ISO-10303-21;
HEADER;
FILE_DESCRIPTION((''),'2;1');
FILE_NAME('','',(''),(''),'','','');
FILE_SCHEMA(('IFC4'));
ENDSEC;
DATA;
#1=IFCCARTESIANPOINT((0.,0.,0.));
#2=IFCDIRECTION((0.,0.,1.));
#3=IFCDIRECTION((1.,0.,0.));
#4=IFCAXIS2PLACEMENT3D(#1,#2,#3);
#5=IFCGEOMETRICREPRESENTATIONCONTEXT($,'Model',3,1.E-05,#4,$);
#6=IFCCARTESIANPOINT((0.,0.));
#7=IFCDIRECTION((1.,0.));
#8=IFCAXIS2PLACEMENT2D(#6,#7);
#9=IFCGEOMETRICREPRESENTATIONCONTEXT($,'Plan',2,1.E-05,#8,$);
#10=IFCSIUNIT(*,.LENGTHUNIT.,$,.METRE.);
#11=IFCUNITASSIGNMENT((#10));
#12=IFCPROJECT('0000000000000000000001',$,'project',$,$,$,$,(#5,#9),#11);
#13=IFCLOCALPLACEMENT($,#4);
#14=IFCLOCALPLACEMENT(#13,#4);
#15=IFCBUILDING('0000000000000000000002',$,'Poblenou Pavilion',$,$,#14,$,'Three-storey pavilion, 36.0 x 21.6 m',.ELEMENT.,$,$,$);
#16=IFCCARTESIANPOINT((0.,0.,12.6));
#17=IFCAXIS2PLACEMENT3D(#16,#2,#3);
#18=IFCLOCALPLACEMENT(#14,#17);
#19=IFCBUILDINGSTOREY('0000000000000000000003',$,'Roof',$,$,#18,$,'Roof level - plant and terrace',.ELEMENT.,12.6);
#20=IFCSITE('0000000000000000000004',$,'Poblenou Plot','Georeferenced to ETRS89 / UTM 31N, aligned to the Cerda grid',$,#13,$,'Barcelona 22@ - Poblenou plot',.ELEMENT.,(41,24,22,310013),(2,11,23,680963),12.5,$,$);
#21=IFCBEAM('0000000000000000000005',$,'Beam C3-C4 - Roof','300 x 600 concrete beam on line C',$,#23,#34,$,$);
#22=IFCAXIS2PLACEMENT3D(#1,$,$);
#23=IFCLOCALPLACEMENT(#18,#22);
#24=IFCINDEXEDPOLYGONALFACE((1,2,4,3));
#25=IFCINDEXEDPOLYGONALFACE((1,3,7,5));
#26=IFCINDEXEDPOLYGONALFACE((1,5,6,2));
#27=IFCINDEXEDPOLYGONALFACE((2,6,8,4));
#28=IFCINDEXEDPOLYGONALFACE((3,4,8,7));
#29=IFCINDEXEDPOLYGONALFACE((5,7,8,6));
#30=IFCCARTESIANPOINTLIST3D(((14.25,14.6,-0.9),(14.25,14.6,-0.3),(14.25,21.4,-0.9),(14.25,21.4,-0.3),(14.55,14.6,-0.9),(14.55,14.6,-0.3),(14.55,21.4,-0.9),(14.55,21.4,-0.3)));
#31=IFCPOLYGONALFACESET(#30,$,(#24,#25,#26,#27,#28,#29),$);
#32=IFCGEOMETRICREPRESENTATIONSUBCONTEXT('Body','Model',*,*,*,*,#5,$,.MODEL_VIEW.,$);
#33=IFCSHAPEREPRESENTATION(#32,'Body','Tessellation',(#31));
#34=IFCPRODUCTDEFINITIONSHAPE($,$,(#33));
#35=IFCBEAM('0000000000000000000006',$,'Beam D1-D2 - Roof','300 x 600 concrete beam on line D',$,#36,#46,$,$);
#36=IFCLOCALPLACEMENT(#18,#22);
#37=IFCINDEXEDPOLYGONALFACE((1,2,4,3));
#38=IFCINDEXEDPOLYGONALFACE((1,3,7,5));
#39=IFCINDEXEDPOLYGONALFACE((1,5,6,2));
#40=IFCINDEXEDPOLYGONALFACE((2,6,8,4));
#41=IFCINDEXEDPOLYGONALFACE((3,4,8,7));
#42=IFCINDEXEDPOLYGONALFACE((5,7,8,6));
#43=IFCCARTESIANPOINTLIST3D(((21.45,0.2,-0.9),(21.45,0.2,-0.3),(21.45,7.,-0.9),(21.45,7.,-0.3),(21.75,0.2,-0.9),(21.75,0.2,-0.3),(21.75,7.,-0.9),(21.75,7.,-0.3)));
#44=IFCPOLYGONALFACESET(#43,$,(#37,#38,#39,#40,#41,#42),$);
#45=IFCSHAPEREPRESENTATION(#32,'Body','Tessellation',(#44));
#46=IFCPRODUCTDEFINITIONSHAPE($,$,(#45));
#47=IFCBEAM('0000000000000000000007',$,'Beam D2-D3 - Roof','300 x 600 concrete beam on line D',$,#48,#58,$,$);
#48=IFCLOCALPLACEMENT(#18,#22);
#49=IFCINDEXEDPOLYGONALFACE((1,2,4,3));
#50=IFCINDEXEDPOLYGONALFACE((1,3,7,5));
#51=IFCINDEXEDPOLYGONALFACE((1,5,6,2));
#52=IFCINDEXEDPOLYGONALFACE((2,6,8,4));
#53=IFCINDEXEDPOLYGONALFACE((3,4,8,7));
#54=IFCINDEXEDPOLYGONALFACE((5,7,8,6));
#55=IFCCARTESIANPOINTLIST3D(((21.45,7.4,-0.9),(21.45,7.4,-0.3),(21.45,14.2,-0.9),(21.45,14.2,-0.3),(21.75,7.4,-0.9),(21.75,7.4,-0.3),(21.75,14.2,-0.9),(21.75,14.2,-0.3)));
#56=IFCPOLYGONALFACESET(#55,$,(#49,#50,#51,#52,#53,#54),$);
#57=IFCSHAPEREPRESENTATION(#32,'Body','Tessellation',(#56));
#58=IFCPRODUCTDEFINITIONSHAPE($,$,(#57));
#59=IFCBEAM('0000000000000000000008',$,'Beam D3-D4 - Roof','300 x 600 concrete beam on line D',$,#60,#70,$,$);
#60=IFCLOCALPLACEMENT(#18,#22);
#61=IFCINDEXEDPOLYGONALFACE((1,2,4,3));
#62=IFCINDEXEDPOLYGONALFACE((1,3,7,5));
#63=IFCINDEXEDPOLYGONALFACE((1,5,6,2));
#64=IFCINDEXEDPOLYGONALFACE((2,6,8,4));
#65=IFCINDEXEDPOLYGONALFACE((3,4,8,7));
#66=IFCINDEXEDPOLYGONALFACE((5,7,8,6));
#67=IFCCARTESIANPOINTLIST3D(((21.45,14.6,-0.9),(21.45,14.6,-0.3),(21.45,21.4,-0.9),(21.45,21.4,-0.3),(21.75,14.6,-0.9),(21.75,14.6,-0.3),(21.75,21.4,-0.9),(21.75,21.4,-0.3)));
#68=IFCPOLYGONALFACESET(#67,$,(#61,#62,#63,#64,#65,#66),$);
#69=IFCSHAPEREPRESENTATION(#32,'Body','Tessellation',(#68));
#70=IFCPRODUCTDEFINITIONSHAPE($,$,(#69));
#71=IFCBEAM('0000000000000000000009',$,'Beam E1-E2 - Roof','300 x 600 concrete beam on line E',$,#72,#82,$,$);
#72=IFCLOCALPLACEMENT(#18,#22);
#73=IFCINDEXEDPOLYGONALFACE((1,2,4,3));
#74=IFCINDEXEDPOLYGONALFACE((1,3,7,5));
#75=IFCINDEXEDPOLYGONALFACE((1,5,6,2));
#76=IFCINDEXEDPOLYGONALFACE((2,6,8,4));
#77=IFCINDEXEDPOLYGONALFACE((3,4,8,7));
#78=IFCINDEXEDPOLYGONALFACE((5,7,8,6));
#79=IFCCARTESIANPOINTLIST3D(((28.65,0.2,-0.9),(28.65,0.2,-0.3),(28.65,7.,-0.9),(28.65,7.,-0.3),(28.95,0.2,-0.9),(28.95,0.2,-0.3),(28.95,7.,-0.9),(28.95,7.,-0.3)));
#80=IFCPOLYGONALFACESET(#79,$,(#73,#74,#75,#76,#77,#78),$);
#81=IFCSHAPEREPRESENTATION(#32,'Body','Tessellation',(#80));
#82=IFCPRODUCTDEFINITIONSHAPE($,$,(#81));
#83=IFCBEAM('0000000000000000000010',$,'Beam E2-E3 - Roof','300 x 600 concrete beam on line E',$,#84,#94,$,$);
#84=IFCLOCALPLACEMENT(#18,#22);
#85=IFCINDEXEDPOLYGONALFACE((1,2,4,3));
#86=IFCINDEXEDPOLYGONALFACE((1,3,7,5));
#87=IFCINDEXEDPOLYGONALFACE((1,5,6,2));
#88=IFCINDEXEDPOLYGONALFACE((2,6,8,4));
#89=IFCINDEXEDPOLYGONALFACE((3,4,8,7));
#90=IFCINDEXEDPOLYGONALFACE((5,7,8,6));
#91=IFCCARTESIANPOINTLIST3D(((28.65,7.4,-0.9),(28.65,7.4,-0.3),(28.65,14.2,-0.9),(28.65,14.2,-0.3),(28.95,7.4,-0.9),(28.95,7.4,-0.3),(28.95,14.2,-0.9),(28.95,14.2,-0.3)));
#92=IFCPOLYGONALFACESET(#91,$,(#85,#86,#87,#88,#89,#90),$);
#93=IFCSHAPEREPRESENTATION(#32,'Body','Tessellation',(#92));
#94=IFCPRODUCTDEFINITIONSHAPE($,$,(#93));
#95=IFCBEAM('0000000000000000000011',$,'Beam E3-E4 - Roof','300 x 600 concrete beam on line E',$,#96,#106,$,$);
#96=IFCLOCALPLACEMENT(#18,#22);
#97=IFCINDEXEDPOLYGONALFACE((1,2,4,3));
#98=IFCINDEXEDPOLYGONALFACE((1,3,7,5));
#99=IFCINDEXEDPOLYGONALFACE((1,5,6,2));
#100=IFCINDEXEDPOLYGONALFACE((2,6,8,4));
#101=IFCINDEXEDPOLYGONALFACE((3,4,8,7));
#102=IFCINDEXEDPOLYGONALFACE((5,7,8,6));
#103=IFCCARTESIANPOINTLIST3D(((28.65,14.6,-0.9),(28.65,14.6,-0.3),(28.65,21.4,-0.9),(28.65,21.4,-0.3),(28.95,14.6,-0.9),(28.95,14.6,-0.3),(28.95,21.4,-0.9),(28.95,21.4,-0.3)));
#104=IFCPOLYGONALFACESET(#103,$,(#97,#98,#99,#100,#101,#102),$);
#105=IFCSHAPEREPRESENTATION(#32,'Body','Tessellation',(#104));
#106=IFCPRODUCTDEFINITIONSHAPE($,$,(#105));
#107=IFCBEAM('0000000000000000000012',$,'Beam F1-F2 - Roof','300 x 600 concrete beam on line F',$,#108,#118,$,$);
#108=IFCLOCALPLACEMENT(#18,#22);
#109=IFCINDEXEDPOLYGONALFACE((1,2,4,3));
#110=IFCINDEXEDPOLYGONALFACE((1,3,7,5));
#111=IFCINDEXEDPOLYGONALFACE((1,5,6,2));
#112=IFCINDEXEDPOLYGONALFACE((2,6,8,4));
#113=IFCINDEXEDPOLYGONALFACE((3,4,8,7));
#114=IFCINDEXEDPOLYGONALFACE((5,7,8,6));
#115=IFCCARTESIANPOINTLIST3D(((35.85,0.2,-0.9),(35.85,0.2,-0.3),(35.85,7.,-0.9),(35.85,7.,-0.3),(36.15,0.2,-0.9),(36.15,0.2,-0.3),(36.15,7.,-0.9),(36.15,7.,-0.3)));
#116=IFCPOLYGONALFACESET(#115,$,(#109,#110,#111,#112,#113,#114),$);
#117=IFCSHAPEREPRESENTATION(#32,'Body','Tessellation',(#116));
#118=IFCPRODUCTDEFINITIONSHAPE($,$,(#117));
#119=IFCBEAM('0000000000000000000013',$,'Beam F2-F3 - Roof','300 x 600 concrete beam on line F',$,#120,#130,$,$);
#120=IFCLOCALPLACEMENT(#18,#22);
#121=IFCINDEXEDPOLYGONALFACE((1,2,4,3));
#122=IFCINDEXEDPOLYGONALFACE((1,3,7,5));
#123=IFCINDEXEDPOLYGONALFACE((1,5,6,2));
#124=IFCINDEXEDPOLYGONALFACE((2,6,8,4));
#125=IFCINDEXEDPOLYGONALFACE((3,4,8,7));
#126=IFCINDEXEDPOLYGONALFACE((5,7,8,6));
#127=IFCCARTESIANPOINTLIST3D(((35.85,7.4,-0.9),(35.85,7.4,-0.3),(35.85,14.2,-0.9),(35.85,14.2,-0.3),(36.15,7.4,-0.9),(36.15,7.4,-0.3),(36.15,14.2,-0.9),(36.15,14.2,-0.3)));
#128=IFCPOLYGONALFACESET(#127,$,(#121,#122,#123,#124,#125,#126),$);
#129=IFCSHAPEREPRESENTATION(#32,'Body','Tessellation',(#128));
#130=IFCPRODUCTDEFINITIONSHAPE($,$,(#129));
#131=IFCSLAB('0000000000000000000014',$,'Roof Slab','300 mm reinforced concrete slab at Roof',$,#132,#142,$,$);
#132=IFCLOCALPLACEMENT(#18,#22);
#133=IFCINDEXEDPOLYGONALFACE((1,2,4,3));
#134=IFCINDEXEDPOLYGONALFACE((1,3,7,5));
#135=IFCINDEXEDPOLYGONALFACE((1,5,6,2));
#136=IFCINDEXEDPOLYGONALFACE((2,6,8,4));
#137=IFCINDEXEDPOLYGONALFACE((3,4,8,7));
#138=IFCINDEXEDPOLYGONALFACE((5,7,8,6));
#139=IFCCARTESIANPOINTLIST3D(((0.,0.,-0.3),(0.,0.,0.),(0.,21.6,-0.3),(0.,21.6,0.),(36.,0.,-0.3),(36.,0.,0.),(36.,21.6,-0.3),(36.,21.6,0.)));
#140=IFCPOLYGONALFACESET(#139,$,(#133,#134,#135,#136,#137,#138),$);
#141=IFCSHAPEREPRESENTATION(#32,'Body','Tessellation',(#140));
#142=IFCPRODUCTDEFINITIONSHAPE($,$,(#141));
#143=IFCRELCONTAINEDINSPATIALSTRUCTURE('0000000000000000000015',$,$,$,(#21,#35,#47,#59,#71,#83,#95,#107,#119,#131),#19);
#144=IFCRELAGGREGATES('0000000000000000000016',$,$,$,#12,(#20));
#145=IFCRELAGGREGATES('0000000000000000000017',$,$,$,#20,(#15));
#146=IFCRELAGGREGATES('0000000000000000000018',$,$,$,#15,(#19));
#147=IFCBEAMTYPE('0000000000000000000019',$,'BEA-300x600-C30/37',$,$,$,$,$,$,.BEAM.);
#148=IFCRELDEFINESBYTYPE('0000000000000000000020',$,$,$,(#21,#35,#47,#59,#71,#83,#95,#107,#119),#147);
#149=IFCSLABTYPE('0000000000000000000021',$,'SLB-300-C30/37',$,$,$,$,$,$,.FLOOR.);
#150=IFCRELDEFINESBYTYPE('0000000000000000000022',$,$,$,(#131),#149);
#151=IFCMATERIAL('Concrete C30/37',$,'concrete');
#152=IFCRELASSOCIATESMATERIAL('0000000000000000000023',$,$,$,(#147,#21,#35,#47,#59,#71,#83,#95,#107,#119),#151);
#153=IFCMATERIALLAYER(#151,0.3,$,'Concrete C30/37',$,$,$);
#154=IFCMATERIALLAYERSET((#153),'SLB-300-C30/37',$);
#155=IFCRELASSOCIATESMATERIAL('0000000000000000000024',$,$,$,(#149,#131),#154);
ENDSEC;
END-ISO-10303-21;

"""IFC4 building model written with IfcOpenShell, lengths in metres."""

from ifc_helpers import new_model, si_unit, frame, origin_with_axes, origin_2d_with_axis, place, context, subcontext, project, spatial, line, indexed_curve, rectangle, outline, extrude, material, layer, layer_set, layer_usage, material_profile, profile_set, profile_usage, type_object, element, save


model = new_model("IFC4")

# Units and contexts
model_context = context("Model", 3, precision=1e-05, world=origin_with_axes())
plan_context = context("Plan", 2, precision=1e-05, world=origin_2d_with_axis())
body_context = subcontext(model_context, "Body", "Model", "MODEL_VIEW")
ifc_project = project(units=[si_unit("LENGTHUNIT", "METRE")], contexts=[model_context, plan_context])

# Site, building, storey
site_placement = place(None, origin_with_axes())
site = spatial("IfcSite", under=ifc_project, at=site_placement, Name="Poblenou Plot", Description="Georeferenced to ETRS89 / UTM 31N, aligned to the Cerda grid", LongName="Barcelona 22@ - Poblenou plot", CompositionType="ELEMENT", RefLatitude=(41, 24, 22, 310013), RefLongitude=(2, 11, 23, 680963), RefElevation=12.5)
building_placement = place(site_placement, origin_with_axes())
building = spatial("IfcBuilding", under=site, at=building_placement, Name="Poblenou Pavilion", LongName="Three-storey pavilion, 36.0 x 21.6 m", CompositionType="ELEMENT")
storey_placement = place(building_placement, frame((0.0, 0.0, 12.6), z_axis=(0.0, 0.0, 1.0), x_axis=(1.0, 0.0, 0.0)))
storey = spatial("IfcBuildingStorey", under=building, at=storey_placement, Name="Roof", LongName="Roof level - plant and terrace", CompositionType="ELEMENT", Elevation=12.6)

# Beams
ifc_material = material(Name="Concrete C30/37", Category="concrete")
ifc_material_profile = material_profile(ifc_material, rectangle(XDim=0.3, YDim=0.6))
ifc_profile_set = profile_set([ifc_material_profile], Name="BEA-300x600-C30/37")
beam_type = type_object("IfcBeamType", Name="BEA-300x600-C30/37", PredefinedType="BEAM", material=ifc_profile_set)
ifc_profile_usage_1 = profile_usage(ifc_profile_set)
beam_1_placement = place(storey_placement, frame((14.25, 14.6, -0.9), z_axis=(0.0, 1.0, 0.0), x_axis=(0.0, 0.0, 1.0)))
element("IfcBeam", 1, at=beam_1_placement, inside=storey, type_object=beam_type, material=ifc_profile_usage_1, Name="Beam C3-C4 - Roof", Description="300 x 600 concrete beam on line C", context=body_context, shape_type="SweptSolid", body=[
    extrude(outline(indexed_curve([(0.0, 0.0), (0.6, 0.0), (0.6, 0.3), (0.0, 0.3)], segments=[line(1, 2, 3, 4, 1)])), origin_with_axes(), (0.0, 0.0, 1.0), 6.8),
])
ifc_profile_usage_2 = profile_usage(ifc_profile_set)
beam_2_placement = place(storey_placement, frame((21.45, 0.2, -0.9), z_axis=(0.0, 1.0, 0.0), x_axis=(0.0, 0.0, 1.0)))
element("IfcBeam", 2, at=beam_2_placement, inside=storey, type_object=beam_type, material=ifc_profile_usage_2, Name="Beam D1-D2 - Roof", Description="300 x 600 concrete beam on line D", context=body_context, shape_type="SweptSolid", body=[
    extrude(outline(indexed_curve([(0.0, 0.0), (0.6, 0.0), (0.6, 0.3), (0.0, 0.3)], segments=[line(1, 2, 3, 4, 1)])), origin_with_axes(), (0.0, 0.0, 1.0), 6.8),
])
ifc_profile_usage_3 = profile_usage(ifc_profile_set)
beam_3_placement = place(storey_placement, frame((21.45, 7.4, -0.9), z_axis=(0.0, 1.0, 0.0), x_axis=(0.0, 0.0, 1.0)))
element("IfcBeam", 3, at=beam_3_placement, inside=storey, type_object=beam_type, material=ifc_profile_usage_3, Name="Beam D2-D3 - Roof", Description="300 x 600 concrete beam on line D", context=body_context, shape_type="SweptSolid", body=[
    extrude(outline(indexed_curve([(0.0, 0.0), (0.6, 0.0), (0.6, 0.3), (0.0, 0.3)], segments=[line(1, 2, 3, 4, 1)])), origin_with_axes(), (0.0, 0.0, 1.0), 6.8),
])
ifc_profile_usage_4 = profile_usage(ifc_profile_set)
beam_4_placement = place(storey_placement, frame((21.45, 14.6, -0.9), z_axis=(0.0, 1.0, 0.0), x_axis=(0.0, 0.0, 1.0)))
element("IfcBeam", 4, at=beam_4_placement, inside=storey, type_object=beam_type, material=ifc_profile_usage_4, Name="Beam D3-D4 - Roof", Description="300 x 600 concrete beam on line D", context=body_context, shape_type="SweptSolid", body=[
    extrude(outline(indexed_curve([(0.0, 0.0), (0.6, 0.0), (0.6, 0.3), (0.0, 0.3)], segments=[line(1, 2, 3, 4, 1)])), origin_with_axes(), (0.0, 0.0, 1.0), 6.8),
])
ifc_profile_usage_5 = profile_usage(ifc_profile_set)
beam_5_placement = place(storey_placement, frame((28.65, 0.2, -0.9), z_axis=(0.0, 1.0, 0.0), x_axis=(0.0, 0.0, 1.0)))
element("IfcBeam", 5, at=beam_5_placement, inside=storey, type_object=beam_type, material=ifc_profile_usage_5, Name="Beam E1-E2 - Roof", Description="300 x 600 concrete beam on line E", context=body_context, shape_type="SweptSolid", body=[
    extrude(outline(indexed_curve([(0.0, 0.0), (0.6, 0.0), (0.6, 0.3), (0.0, 0.3)], segments=[line(1, 2, 3, 4, 1)])), origin_with_axes(), (0.0, 0.0, 1.0), 6.8),
])
ifc_profile_usage_6 = profile_usage(ifc_profile_set)
beam_6_placement = place(storey_placement, frame((28.65, 7.4, -0.9), z_axis=(0.0, 1.0, 0.0), x_axis=(0.0, 0.0, 1.0)))
element("IfcBeam", 6, at=beam_6_placement, inside=storey, type_object=beam_type, material=ifc_profile_usage_6, Name="Beam E2-E3 - Roof", Description="300 x 600 concrete beam on line E", context=body_context, shape_type="SweptSolid", body=[
    extrude(outline(indexed_curve([(0.0, 0.0), (0.6, 0.0), (0.6, 0.3), (0.0, 0.3)], segments=[line(1, 2, 3, 4, 1)])), origin_with_axes(), (0.0, 0.0, 1.0), 6.8),
])
ifc_profile_usage_7 = profile_usage(ifc_profile_set)
beam_7_placement = place(storey_placement, frame((28.65, 14.6, -0.9), z_axis=(0.0, 1.0, 0.0), x_axis=(0.0, 0.0, 1.0)))
element("IfcBeam", 7, at=beam_7_placement, inside=storey, type_object=beam_type, material=ifc_profile_usage_7, Name="Beam E3-E4 - Roof", Description="300 x 600 concrete beam on line E", context=body_context, shape_type="SweptSolid", body=[
    extrude(outline(indexed_curve([(0.0, 0.0), (0.6, 0.0), (0.6, 0.3), (0.0, 0.3)], segments=[line(1, 2, 3, 4, 1)])), origin_with_axes(), (0.0, 0.0, 1.0), 6.8),
])
ifc_profile_usage_8 = profile_usage(ifc_profile_set)
beam_8_placement = place(storey_placement, frame((35.85, 0.2, -0.9), z_axis=(0.0, 1.0, 0.0), x_axis=(0.0, 0.0, 1.0)))
element("IfcBeam", 8, at=beam_8_placement, inside=storey, type_object=beam_type, material=ifc_profile_usage_8, Name="Beam F1-F2 - Roof", Description="300 x 600 concrete beam on line F", context=body_context, shape_type="SweptSolid", body=[
    extrude(outline(indexed_curve([(0.0, 0.0), (0.6, 0.0), (0.6, 0.3), (0.0, 0.3)], segments=[line(1, 2, 3, 4, 1)])), origin_with_axes(), (0.0, 0.0, 1.0), 6.8),
])
ifc_profile_usage_9 = profile_usage(ifc_profile_set)
beam_9_placement = place(storey_placement, frame((35.85, 7.4, -0.9), z_axis=(0.0, 1.0, 0.0), x_axis=(0.0, 0.0, 1.0)))
element("IfcBeam", 9, at=beam_9_placement, inside=storey, type_object=beam_type, material=ifc_profile_usage_9, Name="Beam F2-F3 - Roof", Description="300 x 600 concrete beam on line F", context=body_context, shape_type="SweptSolid", body=[
    extrude(outline(indexed_curve([(0.0, 0.0), (0.6, 0.0), (0.6, 0.3), (0.0, 0.3)], segments=[line(1, 2, 3, 4, 1)])), origin_with_axes(), (0.0, 0.0, 1.0), 6.8),
])

# Slab
ifc_layer = layer(ifc_material, 0.3, Name="Concrete C30/37")
ifc_layer_set = layer_set([ifc_layer], Name="SLB-300-C30/37")
ifc_layer_usage = layer_usage(ifc_layer_set, "AXIS3", "POSITIVE", 0.0)
slab_type = type_object("IfcSlabType", Name="SLB-300-C30/37", PredefinedType="FLOOR", material=ifc_layer_set)
slab_placement = place(storey_placement, frame((0.0, 0.0, -0.3), z_axis=(0.0, 0.0, 1.0), x_axis=(1.0, 0.0, 0.0)))
element("IfcSlab", 10, at=slab_placement, inside=storey, type_object=slab_type, material=ifc_layer_usage, Name="Roof Slab", Description="300 mm reinforced concrete slab at Roof", context=body_context, shape_type="SweptSolid", body=[
    extrude(outline(indexed_curve([(0.0, 0.0), (36.0, 0.0), (36.0, 21.6), (0.0, 21.6)], segments=[line(1, 2, 3, 4, 1)])), origin_with_axes(), (0.0, 0.0, 1.0), 0.3),
])

save(model, "model.ifc")
